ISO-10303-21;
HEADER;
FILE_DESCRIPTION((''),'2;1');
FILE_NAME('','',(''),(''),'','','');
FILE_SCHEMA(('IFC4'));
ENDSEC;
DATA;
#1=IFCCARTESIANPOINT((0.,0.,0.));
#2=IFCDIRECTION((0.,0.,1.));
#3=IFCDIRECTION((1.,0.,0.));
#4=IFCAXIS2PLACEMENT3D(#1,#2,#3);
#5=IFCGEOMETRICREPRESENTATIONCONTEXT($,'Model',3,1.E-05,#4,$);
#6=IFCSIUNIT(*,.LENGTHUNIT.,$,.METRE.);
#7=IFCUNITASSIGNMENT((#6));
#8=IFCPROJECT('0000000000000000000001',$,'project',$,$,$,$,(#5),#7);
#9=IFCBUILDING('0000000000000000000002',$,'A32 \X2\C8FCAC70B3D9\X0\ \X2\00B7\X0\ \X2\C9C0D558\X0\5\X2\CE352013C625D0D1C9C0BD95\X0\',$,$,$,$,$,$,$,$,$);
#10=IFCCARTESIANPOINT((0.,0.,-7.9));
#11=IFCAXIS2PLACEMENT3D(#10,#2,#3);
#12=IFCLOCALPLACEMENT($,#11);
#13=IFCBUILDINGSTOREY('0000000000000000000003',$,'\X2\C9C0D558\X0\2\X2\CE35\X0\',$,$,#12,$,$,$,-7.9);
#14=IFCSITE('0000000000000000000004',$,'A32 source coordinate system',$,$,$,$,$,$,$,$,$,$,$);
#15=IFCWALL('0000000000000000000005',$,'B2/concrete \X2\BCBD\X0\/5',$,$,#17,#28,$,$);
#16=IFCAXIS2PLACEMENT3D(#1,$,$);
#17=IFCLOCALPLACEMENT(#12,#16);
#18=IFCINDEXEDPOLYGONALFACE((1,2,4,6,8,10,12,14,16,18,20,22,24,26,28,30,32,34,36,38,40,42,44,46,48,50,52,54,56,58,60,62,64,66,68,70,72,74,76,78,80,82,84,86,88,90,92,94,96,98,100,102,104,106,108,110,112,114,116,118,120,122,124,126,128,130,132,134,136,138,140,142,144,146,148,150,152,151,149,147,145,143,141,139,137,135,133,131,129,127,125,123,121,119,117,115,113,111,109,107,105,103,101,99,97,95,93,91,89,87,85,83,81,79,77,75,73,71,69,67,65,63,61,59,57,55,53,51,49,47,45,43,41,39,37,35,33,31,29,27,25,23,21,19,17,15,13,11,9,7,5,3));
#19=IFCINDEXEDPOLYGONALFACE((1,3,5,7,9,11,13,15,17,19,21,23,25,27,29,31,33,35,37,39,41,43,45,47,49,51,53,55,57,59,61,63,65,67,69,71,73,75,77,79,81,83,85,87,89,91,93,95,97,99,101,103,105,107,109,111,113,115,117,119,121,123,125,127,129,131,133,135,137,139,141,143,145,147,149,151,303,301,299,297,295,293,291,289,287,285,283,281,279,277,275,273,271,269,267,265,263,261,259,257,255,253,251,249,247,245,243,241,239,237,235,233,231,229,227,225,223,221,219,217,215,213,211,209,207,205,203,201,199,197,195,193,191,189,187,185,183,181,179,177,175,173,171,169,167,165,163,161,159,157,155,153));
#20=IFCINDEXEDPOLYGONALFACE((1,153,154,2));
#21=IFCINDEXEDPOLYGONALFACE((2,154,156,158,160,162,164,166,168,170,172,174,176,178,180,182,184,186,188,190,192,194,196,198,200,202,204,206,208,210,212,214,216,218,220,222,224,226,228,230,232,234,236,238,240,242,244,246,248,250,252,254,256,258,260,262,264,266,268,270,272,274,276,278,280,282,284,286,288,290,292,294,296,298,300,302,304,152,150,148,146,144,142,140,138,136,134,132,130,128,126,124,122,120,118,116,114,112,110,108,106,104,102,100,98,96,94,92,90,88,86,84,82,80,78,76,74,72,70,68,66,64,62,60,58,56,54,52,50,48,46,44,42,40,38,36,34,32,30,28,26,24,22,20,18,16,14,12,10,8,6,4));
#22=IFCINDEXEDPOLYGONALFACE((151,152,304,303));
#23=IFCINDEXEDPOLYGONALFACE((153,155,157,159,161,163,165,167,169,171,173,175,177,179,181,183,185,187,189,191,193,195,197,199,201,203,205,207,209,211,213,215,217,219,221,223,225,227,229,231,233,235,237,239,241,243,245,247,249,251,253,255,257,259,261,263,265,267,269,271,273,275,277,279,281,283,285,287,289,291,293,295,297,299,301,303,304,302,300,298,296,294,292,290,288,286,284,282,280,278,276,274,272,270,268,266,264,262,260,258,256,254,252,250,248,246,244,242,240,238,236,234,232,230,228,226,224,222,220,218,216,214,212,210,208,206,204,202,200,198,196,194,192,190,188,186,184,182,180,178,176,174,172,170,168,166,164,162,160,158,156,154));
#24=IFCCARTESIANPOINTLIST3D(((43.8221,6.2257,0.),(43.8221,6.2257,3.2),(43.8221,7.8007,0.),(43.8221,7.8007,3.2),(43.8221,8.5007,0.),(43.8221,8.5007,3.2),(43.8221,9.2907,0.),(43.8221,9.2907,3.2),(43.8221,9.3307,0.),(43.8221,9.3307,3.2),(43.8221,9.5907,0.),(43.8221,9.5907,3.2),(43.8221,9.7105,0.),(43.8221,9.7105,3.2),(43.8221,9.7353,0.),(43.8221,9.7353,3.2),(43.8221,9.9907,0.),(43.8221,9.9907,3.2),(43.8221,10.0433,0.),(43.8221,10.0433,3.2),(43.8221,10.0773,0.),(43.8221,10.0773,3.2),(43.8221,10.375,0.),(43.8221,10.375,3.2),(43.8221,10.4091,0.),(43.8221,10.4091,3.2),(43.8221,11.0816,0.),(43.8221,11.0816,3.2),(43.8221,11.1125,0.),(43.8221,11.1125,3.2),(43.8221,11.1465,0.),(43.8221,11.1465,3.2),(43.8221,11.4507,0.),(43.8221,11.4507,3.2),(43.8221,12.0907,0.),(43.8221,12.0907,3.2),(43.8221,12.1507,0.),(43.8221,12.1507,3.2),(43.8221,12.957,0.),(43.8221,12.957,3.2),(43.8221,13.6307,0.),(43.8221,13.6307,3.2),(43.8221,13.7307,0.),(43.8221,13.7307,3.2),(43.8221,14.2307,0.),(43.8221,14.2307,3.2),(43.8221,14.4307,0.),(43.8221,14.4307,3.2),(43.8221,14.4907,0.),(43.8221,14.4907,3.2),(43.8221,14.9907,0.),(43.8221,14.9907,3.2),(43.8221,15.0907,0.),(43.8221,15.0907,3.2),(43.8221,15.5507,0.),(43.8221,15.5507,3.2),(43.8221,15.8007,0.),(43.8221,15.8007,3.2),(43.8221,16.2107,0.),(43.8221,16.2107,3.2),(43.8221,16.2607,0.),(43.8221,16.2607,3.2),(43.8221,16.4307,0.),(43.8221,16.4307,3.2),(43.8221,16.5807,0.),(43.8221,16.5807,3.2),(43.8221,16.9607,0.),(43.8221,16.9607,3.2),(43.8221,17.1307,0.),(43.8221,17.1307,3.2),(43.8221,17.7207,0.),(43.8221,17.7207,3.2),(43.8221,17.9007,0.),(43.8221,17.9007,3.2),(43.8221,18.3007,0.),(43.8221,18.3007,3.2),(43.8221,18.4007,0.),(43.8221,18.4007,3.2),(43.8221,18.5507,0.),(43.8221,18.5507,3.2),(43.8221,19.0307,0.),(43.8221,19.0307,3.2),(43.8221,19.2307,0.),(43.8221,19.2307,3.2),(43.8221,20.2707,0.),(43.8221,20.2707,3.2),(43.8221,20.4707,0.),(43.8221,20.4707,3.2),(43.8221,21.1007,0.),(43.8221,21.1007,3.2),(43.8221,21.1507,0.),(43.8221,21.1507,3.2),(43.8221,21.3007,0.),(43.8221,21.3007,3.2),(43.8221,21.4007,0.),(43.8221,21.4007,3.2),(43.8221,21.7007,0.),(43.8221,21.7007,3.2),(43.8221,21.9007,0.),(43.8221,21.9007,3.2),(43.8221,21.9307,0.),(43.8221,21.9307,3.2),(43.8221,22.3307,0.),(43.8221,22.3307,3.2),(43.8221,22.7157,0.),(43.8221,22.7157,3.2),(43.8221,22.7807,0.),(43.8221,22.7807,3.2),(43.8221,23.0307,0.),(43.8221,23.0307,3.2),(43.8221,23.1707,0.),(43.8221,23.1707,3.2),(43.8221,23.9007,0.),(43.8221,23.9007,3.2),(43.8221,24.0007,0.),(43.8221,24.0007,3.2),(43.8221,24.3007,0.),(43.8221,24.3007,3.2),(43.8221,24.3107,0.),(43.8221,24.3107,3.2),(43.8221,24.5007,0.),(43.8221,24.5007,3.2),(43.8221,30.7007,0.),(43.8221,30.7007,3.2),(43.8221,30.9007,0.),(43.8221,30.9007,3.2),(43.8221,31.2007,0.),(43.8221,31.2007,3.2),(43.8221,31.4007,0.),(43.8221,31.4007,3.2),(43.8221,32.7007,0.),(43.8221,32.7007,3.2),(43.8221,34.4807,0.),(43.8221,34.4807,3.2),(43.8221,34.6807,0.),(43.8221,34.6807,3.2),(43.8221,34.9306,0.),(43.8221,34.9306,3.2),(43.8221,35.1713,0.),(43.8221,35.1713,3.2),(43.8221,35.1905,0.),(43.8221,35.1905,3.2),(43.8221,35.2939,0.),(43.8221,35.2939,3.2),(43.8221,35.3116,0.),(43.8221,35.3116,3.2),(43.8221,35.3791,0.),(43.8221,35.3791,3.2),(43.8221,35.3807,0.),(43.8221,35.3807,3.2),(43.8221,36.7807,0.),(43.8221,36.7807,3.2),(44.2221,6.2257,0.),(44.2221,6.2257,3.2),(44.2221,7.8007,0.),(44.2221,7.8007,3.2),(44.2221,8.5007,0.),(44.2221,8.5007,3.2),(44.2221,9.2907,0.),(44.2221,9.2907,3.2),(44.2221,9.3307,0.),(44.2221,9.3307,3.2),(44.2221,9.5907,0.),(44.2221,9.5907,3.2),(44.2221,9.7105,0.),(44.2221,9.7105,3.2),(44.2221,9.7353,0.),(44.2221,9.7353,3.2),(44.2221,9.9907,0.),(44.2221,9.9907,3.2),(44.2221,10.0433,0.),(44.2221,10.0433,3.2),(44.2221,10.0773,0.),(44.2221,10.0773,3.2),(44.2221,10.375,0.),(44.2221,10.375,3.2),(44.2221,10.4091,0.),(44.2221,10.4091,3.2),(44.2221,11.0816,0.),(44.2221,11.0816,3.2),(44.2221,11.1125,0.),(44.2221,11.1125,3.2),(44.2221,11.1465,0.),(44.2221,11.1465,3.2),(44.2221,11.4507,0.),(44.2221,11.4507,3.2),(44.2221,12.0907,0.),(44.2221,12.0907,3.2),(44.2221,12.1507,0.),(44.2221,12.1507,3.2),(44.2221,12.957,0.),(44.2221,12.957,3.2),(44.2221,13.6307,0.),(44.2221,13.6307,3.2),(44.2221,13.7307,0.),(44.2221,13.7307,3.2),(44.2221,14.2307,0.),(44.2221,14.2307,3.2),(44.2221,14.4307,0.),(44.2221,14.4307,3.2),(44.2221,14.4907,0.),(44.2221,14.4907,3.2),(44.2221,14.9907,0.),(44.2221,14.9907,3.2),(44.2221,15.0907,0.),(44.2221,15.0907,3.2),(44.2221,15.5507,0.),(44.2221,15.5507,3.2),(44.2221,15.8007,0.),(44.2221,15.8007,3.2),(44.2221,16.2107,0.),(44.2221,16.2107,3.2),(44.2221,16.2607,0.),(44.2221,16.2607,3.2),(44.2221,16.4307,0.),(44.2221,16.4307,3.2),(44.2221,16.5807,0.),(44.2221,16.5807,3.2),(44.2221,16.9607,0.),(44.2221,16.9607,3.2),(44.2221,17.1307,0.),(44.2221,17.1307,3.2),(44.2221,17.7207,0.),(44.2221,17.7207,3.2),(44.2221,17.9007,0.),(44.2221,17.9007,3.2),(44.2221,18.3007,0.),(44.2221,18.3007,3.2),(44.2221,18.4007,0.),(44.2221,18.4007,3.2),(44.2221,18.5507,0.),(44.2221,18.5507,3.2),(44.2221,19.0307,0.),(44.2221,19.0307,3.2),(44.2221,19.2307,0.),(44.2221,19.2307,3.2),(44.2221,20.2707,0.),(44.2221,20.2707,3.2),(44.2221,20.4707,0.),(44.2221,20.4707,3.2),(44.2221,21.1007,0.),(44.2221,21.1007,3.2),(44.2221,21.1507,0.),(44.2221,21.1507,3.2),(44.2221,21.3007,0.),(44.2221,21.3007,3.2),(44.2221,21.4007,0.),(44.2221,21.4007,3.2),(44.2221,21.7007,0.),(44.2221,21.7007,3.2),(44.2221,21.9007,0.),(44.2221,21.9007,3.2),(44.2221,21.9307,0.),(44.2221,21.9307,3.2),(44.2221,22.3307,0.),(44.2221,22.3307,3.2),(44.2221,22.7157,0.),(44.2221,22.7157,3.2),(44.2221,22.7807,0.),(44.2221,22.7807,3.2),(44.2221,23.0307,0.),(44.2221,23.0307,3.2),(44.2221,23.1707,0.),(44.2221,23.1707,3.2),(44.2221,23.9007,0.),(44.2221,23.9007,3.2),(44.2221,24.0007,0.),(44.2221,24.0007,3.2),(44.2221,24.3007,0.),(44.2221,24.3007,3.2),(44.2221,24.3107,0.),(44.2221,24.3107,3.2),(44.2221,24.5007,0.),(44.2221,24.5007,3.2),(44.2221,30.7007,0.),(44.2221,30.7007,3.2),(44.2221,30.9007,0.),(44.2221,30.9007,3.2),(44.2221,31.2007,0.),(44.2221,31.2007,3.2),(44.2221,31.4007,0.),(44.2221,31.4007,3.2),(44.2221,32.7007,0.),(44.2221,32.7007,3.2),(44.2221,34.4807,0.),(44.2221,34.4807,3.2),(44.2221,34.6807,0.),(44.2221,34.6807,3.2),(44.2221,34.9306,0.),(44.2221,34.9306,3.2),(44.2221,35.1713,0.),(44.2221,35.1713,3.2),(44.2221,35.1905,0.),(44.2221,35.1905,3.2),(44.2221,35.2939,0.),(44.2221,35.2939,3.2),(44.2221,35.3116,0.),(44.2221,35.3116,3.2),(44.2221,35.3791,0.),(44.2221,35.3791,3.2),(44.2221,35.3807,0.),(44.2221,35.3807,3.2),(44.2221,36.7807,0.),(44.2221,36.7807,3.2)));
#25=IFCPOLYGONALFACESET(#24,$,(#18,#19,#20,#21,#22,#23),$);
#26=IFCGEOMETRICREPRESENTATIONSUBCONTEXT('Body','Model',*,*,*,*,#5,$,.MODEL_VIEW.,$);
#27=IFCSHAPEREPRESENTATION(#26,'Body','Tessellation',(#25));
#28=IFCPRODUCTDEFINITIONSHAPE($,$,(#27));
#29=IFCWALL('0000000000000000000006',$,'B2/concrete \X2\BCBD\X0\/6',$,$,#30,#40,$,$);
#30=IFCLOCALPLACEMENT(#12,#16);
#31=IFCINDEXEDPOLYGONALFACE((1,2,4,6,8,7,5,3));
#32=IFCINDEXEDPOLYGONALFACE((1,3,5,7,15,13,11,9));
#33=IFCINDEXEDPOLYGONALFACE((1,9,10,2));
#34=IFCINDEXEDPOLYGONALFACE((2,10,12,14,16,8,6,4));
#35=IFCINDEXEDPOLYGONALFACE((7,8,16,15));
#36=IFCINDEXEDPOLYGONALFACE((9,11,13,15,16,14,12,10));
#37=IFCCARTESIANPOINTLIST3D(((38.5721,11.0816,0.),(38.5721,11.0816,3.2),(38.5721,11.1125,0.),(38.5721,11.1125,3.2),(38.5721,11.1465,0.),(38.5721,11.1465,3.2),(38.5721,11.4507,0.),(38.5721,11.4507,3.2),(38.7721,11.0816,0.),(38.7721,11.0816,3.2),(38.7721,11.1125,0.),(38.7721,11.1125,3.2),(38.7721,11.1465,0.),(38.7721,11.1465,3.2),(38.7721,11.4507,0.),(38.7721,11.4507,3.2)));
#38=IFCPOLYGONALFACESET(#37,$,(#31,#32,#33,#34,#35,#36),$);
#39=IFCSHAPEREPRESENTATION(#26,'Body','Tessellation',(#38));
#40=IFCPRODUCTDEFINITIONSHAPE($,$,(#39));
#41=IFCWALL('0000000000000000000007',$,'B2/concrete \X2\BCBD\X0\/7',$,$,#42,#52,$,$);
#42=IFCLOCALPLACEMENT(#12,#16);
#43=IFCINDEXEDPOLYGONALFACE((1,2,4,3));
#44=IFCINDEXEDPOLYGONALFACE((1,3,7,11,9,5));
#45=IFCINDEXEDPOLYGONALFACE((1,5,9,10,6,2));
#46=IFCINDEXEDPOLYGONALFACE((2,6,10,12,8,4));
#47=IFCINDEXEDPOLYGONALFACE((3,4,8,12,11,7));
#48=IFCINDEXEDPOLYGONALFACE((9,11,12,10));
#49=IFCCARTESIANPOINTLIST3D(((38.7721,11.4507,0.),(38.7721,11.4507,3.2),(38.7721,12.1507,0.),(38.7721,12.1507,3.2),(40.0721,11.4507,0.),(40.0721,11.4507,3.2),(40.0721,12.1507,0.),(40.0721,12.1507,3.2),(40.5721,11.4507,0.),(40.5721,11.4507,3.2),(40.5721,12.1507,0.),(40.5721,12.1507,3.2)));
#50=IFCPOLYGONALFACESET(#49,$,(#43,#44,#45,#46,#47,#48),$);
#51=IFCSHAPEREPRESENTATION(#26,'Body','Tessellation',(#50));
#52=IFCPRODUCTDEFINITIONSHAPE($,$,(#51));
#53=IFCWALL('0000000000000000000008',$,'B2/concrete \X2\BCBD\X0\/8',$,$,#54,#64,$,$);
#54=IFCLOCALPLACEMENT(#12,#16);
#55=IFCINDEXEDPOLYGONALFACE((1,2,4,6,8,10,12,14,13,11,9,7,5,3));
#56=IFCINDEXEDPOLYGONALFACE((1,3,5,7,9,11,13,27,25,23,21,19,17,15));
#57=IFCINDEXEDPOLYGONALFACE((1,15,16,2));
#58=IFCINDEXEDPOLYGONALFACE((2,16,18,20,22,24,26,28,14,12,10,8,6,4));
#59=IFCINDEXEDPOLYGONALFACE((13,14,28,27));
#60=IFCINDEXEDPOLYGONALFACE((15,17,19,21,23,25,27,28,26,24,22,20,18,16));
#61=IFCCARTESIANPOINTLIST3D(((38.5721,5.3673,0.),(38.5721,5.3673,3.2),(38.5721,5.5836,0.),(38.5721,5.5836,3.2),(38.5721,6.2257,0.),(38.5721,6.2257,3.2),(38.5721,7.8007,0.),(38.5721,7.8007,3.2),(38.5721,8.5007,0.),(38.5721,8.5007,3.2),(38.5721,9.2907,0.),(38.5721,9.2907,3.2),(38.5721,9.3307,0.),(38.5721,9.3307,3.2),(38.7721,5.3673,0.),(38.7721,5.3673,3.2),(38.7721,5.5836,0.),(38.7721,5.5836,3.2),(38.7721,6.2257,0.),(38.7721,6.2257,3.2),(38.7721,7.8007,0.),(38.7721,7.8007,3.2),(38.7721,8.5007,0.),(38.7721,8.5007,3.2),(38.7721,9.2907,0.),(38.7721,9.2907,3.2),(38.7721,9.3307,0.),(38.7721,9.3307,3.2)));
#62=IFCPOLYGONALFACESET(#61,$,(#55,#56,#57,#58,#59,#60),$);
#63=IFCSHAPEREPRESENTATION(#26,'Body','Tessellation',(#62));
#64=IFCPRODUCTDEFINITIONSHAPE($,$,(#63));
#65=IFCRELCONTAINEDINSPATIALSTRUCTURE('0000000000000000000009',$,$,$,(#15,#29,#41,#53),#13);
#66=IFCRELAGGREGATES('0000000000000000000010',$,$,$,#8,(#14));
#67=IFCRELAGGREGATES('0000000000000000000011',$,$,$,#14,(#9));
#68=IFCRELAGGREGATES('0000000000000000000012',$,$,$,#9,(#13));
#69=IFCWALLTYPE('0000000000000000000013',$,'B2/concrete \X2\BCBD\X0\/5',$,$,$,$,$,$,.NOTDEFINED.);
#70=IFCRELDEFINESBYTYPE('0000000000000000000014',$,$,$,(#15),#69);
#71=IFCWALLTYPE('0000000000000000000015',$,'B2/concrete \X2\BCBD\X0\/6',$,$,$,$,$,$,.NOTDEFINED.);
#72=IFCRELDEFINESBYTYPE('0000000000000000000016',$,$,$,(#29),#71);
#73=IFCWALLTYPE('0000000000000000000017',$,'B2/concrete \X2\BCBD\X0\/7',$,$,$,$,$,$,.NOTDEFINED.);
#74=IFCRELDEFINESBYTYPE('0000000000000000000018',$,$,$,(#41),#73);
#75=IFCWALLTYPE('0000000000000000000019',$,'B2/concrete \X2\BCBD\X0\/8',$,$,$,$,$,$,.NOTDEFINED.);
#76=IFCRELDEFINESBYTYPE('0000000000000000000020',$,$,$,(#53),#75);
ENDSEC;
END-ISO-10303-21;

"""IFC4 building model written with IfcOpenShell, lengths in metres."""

from ifc_helpers import new_model, si_unit, frame, origin, origin_with_axes, place, context, subcontext, project, spatial, polyline, outline, extrude, source, transform, mapped, type_object, type_shapes, element, save


model = new_model("IFC4")

# Units and contexts
model_context = context("Model", 3, precision=1e-05, world=origin_with_axes())
body_context = subcontext(model_context, "Body", "Model", "MODEL_VIEW")
ifc_project = project(units=[si_unit("LENGTHUNIT", "METRE")], contexts=[model_context])

# Site, building, storey
site = spatial("IfcSite", under=ifc_project, Name="A32 source coordinate system")
building = spatial("IfcBuilding", under=site, Name="A32 주거동 · 지하5층–옥탑지붕")
storey_placement = place(None, frame((0.0, 0.0, -7.9), z_axis=(0.0, 0.0, 1.0), x_axis=(1.0, 0.0, 0.0)))
storey = spatial("IfcBuildingStorey", under=building, at=storey_placement, Name="지하2층", Elevation=-7.9)

# Walls
wall_type_1 = type_object("IfcWallType", Name="B2/concrete 벽/5", PredefinedType="NOTDEFINED")
shared_shape_1 = source(origin(), body_context, "Body", "SweptSolid", [
    extrude(outline(polyline([(44.2221, 35.3791), (44.2221, 35.3116), (44.2221, 35.2939), (44.2221, 35.1905), (44.2221, 35.1713), (44.2221, 34.9306), (44.2221, 34.6807), (44.2221, 34.4807), (44.2221, 32.7007), (44.2221, 31.4007), (44.2221, 31.2007), (44.2221, 30.9007), (44.2221, 30.7007), (44.2221, 24.5007), (44.2221, 24.3107), (44.2221, 24.3007), (44.2221, 24.0007), (44.2221, 23.9007), (44.2221, 23.1707), (44.2221, 23.0307), (44.2221, 22.7807), (44.2221, 22.7157), (44.2221, 22.3307), (44.2221, 21.9307), (44.2221, 21.9007), (44.2221, 21.7007), (44.2221, 21.4007), (44.2221, 21.3007), (44.2221, 21.1507), (44.2221, 21.1007), (44.2221, 20.4707), (44.2221, 20.2707), (44.2221, 19.2307), (44.2221, 19.0307), (44.2221, 18.5507), (44.2221, 18.4007), (44.2221, 18.3007), (44.2221, 17.9007), (44.2221, 17.7207), (44.2221, 17.1307), (44.2221, 16.9607), (44.2221, 16.5807), (44.2221, 16.4307), (44.2221, 16.2607), (44.2221, 16.2107), (44.2221, 15.8007), (44.2221, 15.5507), (44.2221, 15.0907), (44.2221, 14.9907), (44.2221, 14.4907), (44.2221, 14.4307), (44.2221, 14.2307), (44.2221, 13.7307), (44.2221, 13.6307), (44.2221, 12.957), (44.2221, 12.1507), (44.2221, 12.0907), (44.2221, 11.4507), (44.2221, 11.1465), (44.2221, 11.1125), (44.2221, 11.0816), (44.2221, 10.4091), (44.2221, 10.375), (44.2221, 10.0773), (44.2221, 10.0433), (44.2221, 9.9907), (44.2221, 9.7353), (44.2221, 9.7105), (44.2221, 9.5907), (44.2221, 9.3307), (44.2221, 9.2907), (44.2221, 8.5007), (44.2221, 7.8007), (44.2221, 6.2257), (43.8221, 6.2257), (43.8221, 7.8007), (43.8221, 8.5007), (43.8221, 9.2907), (43.8221, 9.3307), (43.8221, 9.5907), (43.8221, 9.7105), (43.8221, 9.7353), (43.8221, 9.9907), (43.8221, 10.0433), (43.8221, 10.0773), (43.8221, 10.375), (43.8221, 10.4091), (43.8221, 11.0816), (43.8221, 11.1125), (43.8221, 11.1465), (43.8221, 11.4507), (43.8221, 12.0907), (43.8221, 12.1507), (43.8221, 12.957), (43.8221, 13.6307), (43.8221, 13.7307), (43.8221, 14.2307), (43.8221, 14.4307), (43.8221, 14.4907), (43.8221, 14.9907), (43.8221, 15.0907), (43.8221, 15.5507), (43.8221, 15.8007), (43.8221, 16.2107), (43.8221, 16.2607), (43.8221, 16.4307), (43.8221, 16.5807), (43.8221, 16.9607), (43.8221, 17.1307), (43.8221, 17.7207), (43.8221, 17.9007), (43.8221, 18.3007), (43.8221, 18.4007), (43.8221, 18.5507), (43.8221, 19.0307), (43.8221, 19.2307), (43.8221, 20.2707), (43.8221, 20.4707), (43.8221, 21.1007), (43.8221, 21.1507), (43.8221, 21.3007), (43.8221, 21.4007), (43.8221, 21.7007), (43.8221, 21.9007), (43.8221, 21.9307), (43.8221, 22.3307), (43.8221, 22.7157), (43.8221, 22.7807), (43.8221, 23.0307), (43.8221, 23.1707), (43.8221, 23.9007), (43.8221, 24.0007), (43.8221, 24.3007), (43.8221, 24.3107), (43.8221, 24.5007), (43.8221, 30.7007), (43.8221, 30.9007), (43.8221, 31.2007), (43.8221, 31.4007), (43.8221, 32.7007), (43.8221, 34.4807), (43.8221, 34.6807), (43.8221, 34.9306), (43.8221, 35.1713), (43.8221, 35.1905), (43.8221, 35.2939), (43.8221, 35.3116), (43.8221, 35.3791), (43.8221, 35.3807), (43.8221, 36.7807), (44.2221, 36.7807), (44.2221, 35.3807), (44.2221, 35.3791)])), origin(), (0.0, 0.0, 1.0), 3.2),
])
type_shapes(wall_type_1, [shared_shape_1])
wall_1_placement = place(storey_placement, origin_with_axes())
element("IfcWall", 1, at=wall_1_placement, inside=storey, type_object=wall_type_1, Name="B2/concrete 벽/5", context=body_context, shape_type="MappedRepresentation", body=[
    mapped(shared_shape_1, transform((0.0, 0.0, 0.0), scale=1.0)),
])
wall_type_2 = type_object("IfcWallType", Name="B2/concrete 벽/6", PredefinedType="NOTDEFINED")
shared_shape_2 = source(origin(), body_context, "Body", "SweptSolid", [
    extrude(outline(polyline([(38.7721, 11.1125), (38.7721, 11.0816), (38.5721, 11.0816), (38.5721, 11.1125), (38.5721, 11.1465), (38.5721, 11.4507), (38.7721, 11.4507), (38.7721, 11.1465), (38.7721, 11.1125)])), origin(), (0.0, 0.0, 1.0), 3.2),
])
type_shapes(wall_type_2, [shared_shape_2])
wall_2_placement = place(storey_placement, origin_with_axes())
element("IfcWall", 2, at=wall_2_placement, inside=storey, type_object=wall_type_2, Name="B2/concrete 벽/6", context=body_context, shape_type="MappedRepresentation", body=[
    mapped(shared_shape_2, transform((0.0, 0.0, 0.0), scale=1.0)),
])
wall_type_3 = type_object("IfcWallType", Name="B2/concrete 벽/7", PredefinedType="NOTDEFINED")
shared_shape_3 = source(origin(), body_context, "Body", "SweptSolid", [
    extrude(outline(polyline([(40.5721, 12.1507), (40.5721, 11.4507), (40.0721, 11.4507), (38.7721, 11.4507), (38.7721, 12.1507), (40.0721, 12.1507), (40.5721, 12.1507)])), origin(), (0.0, 0.0, 1.0), 3.2),
])
type_shapes(wall_type_3, [shared_shape_3])
wall_3_placement = place(storey_placement, origin_with_axes())
element("IfcWall", 3, at=wall_3_placement, inside=storey, type_object=wall_type_3, Name="B2/concrete 벽/7", context=body_context, shape_type="MappedRepresentation", body=[
    mapped(shared_shape_3, transform((0.0, 0.0, 0.0), scale=1.0)),
])
wall_type_4 = type_object("IfcWallType", Name="B2/concrete 벽/8", PredefinedType="NOTDEFINED")
shared_shape_4 = source(origin(), body_context, "Body", "SweptSolid", [
    extrude(outline(polyline([(38.7721, 6.2257), (38.7721, 5.5836), (38.7721, 5.3673), (38.5721, 5.3673), (38.5721, 5.5836), (38.5721, 6.2257), (38.5721, 7.8007), (38.5721, 8.5007), (38.5721, 9.2907), (38.5721, 9.3307), (38.7721, 9.3307), (38.7721, 9.2907), (38.7721, 8.5007), (38.7721, 7.8007), (38.7721, 6.2257)])), origin(), (0.0, 0.0, 1.0), 3.2),
])
type_shapes(wall_type_4, [shared_shape_4])
wall_4_placement = place(storey_placement, origin_with_axes())
element("IfcWall", 4, at=wall_4_placement, inside=storey, type_object=wall_type_4, Name="B2/concrete 벽/8", context=body_context, shape_type="MappedRepresentation", body=[
    mapped(shared_shape_4, transform((0.0, 0.0, 0.0), scale=1.0)),
])

save(model, "model.ifc")
